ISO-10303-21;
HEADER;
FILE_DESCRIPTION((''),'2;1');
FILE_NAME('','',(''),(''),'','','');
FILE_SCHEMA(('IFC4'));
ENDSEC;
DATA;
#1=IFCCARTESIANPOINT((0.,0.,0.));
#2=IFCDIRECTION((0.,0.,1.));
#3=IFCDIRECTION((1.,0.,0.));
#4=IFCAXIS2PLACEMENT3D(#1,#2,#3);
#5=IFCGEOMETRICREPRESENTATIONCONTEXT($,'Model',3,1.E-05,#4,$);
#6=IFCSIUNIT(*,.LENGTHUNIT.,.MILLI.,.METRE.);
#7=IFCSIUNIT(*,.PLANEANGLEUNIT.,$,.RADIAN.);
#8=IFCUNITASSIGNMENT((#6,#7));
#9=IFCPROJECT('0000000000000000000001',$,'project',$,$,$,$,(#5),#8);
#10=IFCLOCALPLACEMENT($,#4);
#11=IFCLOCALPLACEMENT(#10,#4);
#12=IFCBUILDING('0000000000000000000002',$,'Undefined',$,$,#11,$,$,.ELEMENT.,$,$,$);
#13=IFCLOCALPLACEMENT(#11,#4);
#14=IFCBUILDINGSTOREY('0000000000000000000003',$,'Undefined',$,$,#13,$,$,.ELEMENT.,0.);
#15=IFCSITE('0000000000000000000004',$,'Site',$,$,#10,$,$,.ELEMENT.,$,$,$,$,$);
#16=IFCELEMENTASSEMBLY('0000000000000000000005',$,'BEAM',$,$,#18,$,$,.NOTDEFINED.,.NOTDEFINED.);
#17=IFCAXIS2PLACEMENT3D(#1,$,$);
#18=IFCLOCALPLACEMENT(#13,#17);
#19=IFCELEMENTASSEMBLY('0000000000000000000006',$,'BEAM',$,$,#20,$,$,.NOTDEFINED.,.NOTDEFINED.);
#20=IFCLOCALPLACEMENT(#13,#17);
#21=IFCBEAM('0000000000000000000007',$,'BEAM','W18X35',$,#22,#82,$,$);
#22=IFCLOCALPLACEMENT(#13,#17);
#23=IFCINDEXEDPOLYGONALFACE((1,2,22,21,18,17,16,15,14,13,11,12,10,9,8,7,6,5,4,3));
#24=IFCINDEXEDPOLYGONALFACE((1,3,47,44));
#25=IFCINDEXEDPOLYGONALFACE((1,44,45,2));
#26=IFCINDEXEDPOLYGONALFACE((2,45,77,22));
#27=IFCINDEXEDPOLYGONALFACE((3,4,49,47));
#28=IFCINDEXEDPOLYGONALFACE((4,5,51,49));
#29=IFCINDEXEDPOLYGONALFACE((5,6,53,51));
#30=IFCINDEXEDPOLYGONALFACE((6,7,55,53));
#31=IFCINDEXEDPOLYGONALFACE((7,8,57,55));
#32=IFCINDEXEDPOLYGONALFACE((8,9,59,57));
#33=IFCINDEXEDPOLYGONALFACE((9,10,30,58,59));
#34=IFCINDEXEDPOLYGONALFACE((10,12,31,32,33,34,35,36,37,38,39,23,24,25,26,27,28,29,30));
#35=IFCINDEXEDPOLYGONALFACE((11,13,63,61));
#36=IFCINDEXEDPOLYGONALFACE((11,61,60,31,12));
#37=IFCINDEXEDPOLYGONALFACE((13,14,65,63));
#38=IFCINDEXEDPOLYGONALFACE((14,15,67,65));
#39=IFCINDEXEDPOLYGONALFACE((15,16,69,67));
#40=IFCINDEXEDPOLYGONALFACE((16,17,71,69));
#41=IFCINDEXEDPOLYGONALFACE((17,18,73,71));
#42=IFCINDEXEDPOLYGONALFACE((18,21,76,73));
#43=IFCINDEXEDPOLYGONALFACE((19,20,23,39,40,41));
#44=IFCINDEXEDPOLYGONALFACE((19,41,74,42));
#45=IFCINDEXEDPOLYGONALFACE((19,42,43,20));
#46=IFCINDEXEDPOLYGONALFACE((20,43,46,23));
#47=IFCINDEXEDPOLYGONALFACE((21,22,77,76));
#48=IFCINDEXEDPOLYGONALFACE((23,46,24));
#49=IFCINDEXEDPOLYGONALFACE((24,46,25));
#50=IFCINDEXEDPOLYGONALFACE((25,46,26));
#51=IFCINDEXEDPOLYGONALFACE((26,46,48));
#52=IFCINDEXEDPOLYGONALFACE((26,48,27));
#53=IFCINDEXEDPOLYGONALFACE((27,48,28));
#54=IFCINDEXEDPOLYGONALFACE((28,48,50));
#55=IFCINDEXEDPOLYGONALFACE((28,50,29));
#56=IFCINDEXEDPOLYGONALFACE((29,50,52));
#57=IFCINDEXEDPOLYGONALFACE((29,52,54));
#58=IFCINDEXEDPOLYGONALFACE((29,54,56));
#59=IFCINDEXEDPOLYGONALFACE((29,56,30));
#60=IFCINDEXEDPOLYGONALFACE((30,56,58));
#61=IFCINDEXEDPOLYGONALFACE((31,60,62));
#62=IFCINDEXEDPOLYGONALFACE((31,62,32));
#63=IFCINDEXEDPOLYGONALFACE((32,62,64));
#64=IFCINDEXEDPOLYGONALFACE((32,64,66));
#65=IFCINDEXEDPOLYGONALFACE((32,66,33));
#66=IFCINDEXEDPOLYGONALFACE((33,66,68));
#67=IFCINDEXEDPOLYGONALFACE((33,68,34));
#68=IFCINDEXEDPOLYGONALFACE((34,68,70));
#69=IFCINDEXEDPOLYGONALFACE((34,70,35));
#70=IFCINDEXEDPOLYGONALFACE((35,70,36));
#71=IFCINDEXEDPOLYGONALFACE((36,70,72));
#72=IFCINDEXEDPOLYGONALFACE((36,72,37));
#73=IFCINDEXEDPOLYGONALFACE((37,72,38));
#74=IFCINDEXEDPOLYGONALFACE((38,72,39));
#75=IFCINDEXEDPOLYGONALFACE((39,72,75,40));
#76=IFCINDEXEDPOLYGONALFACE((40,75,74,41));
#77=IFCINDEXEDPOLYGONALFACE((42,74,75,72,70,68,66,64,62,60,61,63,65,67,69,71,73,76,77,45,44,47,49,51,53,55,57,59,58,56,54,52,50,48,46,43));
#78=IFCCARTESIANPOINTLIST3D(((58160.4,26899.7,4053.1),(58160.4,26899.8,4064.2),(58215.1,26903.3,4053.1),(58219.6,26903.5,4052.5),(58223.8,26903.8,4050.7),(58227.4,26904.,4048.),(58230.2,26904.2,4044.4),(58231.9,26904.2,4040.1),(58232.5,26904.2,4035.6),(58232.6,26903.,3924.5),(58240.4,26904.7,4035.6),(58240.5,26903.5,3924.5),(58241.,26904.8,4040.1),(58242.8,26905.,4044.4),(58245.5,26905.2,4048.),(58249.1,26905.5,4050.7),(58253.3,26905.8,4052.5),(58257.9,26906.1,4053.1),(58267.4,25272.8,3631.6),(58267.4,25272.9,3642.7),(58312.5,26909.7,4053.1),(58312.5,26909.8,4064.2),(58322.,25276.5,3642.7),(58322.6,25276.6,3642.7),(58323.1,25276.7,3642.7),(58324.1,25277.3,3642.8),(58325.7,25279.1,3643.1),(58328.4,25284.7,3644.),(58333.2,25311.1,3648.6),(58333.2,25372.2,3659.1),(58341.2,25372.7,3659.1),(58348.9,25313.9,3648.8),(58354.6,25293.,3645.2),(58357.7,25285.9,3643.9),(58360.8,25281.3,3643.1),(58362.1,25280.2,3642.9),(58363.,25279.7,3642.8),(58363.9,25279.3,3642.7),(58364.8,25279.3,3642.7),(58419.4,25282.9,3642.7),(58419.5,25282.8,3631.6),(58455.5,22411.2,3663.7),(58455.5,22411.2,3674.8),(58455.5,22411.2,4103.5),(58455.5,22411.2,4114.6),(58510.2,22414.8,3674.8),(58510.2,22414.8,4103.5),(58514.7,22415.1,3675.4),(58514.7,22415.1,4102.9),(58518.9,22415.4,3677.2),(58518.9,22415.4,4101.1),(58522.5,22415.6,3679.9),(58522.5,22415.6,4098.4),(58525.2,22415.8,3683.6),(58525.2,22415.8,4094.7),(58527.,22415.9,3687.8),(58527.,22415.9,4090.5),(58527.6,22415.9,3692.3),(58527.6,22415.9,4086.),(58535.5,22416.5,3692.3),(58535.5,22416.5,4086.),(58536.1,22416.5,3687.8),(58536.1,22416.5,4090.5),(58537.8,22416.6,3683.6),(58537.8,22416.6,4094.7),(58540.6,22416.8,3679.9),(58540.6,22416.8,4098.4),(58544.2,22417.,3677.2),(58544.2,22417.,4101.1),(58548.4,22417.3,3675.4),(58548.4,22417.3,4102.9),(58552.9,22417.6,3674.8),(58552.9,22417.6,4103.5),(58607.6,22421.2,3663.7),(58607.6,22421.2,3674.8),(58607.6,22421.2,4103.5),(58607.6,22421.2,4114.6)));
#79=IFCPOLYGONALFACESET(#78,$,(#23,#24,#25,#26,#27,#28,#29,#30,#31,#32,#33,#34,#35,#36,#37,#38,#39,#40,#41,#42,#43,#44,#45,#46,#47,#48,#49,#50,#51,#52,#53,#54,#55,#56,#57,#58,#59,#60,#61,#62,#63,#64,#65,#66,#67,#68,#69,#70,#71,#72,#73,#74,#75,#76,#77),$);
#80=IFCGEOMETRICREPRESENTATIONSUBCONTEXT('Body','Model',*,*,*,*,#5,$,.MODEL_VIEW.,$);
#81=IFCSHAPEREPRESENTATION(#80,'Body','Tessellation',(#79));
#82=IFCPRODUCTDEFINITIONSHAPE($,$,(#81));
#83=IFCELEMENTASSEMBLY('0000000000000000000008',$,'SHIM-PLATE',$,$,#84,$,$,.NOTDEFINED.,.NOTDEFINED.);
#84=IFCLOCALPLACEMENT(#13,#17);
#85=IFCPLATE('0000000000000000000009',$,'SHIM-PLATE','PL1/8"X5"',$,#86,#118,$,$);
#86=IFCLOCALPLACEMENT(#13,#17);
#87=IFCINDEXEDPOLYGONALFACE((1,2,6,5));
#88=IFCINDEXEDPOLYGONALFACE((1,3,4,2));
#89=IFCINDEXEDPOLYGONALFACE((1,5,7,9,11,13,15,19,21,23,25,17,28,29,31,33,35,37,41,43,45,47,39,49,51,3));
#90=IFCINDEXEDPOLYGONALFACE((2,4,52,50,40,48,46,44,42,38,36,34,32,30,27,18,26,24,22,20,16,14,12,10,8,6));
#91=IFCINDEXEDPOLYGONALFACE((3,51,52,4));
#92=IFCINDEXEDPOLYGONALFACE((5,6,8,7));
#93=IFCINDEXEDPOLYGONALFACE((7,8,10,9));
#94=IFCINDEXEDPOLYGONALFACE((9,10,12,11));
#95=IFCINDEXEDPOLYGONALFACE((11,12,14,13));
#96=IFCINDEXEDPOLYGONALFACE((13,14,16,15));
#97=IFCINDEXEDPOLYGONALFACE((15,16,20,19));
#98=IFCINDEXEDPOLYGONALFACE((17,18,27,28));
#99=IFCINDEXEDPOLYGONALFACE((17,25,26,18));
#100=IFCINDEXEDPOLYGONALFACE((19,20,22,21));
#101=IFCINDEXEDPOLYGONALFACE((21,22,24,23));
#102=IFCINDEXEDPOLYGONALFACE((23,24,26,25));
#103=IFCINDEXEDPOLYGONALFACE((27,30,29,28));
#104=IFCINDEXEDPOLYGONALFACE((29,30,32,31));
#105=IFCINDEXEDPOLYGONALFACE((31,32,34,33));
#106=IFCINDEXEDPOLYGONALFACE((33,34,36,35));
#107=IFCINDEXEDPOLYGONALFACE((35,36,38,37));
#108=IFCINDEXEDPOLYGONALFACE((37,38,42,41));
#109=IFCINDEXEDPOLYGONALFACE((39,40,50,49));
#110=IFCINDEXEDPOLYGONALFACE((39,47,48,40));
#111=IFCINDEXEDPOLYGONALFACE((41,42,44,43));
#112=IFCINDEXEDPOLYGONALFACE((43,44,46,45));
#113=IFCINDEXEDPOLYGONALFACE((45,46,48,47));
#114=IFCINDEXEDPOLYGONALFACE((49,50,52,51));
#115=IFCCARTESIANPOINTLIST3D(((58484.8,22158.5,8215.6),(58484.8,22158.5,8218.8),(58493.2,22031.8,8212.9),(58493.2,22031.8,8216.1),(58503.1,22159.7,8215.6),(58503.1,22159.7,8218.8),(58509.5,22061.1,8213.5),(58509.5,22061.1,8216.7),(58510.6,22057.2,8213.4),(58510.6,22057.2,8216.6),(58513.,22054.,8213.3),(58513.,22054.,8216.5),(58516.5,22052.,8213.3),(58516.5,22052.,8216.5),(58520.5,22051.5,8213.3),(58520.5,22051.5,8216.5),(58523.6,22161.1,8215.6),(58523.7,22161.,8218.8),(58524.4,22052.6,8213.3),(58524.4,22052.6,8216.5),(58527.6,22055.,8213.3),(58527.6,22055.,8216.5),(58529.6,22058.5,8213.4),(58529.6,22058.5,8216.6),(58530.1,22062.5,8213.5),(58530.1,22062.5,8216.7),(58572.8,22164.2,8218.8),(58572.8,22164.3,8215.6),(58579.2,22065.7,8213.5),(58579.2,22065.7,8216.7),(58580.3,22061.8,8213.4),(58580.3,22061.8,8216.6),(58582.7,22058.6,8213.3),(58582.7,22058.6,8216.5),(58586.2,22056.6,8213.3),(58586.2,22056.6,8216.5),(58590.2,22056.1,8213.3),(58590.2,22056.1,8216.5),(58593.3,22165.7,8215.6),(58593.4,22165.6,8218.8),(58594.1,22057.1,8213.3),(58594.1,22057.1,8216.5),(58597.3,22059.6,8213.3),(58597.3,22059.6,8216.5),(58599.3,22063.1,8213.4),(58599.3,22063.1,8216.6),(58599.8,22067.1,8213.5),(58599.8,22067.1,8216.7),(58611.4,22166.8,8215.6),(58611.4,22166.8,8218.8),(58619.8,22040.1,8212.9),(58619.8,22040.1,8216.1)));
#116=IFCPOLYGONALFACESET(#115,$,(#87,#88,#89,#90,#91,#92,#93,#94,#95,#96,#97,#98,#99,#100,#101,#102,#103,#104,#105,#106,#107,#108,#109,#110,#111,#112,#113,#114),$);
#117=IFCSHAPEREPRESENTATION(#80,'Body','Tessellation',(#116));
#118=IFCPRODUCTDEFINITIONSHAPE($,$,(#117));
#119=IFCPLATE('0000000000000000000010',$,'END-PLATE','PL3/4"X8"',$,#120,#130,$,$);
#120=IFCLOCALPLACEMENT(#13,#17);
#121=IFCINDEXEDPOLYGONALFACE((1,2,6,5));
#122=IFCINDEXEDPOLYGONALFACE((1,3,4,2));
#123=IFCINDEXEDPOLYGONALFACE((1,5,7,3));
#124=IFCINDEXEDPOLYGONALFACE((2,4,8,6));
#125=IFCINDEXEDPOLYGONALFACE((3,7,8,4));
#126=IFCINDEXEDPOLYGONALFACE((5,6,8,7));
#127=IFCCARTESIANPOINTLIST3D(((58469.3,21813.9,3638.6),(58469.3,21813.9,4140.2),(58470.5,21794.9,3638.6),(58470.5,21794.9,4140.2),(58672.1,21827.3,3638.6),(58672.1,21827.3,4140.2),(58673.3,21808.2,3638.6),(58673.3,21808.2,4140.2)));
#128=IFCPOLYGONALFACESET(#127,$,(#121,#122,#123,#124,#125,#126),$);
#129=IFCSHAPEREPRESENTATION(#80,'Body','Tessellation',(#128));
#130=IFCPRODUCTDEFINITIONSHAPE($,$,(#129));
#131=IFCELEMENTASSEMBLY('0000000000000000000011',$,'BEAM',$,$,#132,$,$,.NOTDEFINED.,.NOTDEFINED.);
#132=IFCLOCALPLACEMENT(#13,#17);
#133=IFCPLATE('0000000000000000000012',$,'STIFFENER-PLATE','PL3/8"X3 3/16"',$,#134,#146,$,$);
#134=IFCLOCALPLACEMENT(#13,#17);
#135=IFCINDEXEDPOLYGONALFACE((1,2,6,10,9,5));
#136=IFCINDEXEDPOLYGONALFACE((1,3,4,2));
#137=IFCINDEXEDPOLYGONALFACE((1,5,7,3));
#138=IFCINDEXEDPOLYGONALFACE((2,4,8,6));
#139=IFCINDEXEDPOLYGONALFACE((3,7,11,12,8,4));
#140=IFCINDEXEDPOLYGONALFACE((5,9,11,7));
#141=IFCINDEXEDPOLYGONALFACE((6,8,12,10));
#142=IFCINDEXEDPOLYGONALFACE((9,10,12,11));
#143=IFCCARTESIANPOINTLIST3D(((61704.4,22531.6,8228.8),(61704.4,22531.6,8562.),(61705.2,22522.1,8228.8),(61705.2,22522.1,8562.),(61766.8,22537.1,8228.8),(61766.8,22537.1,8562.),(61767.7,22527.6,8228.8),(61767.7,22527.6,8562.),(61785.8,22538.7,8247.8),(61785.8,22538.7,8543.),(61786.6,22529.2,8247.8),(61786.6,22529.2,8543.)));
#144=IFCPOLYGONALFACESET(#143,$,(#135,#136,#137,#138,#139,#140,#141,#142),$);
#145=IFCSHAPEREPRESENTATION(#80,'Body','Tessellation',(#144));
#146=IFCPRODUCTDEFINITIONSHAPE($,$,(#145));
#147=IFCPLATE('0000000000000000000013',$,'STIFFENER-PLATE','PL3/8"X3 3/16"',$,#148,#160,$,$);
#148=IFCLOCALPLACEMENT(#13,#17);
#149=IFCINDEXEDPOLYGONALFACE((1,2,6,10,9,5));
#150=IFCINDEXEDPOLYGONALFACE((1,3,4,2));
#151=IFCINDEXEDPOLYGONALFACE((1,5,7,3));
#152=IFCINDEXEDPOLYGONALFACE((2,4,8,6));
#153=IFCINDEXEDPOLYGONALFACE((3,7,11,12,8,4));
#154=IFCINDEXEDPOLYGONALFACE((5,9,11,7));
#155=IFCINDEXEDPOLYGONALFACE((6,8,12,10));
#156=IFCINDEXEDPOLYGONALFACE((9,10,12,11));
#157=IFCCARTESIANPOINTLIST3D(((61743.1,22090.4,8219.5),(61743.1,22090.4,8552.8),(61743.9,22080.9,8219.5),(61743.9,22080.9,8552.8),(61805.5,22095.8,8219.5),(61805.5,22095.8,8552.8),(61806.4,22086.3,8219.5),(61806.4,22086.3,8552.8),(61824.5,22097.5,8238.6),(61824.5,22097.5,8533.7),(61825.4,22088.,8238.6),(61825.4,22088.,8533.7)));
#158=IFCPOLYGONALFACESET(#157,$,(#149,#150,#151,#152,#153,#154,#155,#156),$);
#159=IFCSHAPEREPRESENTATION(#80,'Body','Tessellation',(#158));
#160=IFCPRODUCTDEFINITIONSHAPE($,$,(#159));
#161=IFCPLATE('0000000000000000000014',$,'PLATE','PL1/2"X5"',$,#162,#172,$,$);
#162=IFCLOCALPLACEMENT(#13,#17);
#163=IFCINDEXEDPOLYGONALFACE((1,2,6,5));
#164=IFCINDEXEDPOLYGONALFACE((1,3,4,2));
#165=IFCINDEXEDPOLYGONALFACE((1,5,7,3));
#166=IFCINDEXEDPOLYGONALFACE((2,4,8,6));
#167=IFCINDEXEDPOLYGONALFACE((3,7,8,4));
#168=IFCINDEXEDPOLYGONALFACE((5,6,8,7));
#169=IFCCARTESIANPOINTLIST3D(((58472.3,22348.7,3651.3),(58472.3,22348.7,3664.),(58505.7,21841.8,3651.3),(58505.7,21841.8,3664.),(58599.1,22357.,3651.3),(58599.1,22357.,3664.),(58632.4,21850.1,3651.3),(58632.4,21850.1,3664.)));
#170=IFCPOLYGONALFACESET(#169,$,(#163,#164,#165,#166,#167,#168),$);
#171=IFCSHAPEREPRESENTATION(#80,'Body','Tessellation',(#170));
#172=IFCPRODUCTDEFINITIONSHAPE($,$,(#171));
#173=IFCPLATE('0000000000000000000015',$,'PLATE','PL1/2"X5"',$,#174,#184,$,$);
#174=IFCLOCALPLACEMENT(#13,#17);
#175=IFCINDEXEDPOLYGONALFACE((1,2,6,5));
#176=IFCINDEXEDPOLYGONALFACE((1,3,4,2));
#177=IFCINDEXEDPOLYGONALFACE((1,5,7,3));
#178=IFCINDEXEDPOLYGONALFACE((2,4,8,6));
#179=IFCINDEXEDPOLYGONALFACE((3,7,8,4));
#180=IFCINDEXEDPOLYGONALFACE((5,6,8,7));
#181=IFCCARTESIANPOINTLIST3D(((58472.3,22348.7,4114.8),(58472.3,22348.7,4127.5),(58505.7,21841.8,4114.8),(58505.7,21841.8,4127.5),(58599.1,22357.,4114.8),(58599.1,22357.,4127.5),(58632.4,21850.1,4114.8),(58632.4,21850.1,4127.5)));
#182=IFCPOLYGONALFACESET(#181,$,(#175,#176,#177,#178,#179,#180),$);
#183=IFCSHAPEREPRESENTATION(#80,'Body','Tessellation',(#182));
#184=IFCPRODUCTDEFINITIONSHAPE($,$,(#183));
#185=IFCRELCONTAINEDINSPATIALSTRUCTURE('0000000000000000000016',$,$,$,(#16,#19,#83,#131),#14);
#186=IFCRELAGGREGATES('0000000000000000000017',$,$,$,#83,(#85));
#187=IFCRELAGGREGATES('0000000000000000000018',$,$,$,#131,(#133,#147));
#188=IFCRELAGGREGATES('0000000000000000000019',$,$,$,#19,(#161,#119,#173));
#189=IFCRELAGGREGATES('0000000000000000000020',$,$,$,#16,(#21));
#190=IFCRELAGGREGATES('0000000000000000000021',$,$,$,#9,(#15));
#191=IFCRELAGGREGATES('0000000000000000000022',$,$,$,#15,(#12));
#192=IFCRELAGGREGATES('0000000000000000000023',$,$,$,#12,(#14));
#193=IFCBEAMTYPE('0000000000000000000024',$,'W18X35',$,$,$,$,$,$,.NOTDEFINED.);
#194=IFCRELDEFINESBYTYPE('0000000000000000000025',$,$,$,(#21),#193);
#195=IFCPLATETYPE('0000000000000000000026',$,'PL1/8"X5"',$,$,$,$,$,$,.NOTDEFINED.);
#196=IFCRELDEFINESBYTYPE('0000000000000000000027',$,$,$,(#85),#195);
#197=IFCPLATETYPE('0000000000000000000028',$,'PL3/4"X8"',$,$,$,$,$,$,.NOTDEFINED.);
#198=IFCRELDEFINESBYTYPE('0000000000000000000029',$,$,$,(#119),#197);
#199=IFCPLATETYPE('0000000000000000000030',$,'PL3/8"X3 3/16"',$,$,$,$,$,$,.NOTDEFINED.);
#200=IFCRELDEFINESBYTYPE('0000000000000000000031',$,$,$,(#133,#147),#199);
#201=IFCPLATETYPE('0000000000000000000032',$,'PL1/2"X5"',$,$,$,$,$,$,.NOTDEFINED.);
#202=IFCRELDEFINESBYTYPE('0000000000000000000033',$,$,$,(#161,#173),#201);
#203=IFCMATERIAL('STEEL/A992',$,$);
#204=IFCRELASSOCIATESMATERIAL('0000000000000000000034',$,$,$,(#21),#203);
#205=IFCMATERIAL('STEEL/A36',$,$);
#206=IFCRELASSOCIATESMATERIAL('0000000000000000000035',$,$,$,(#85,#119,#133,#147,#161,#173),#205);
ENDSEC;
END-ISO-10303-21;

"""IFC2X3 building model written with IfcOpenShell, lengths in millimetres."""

from ifc_helpers import new_model, si_unit, frame, origin_with_axes, origin_2d_with_axis, place, context, subcontext, project, spatial, polyline, i_section, outline, extrude, boolean, halfspace, material, type_object, element, aggregate, save


model = new_model("IFC2X3")

# Units and contexts
model_context = context("Model", 3, precision=1e-05, world=origin_with_axes())
body_context = subcontext(model_context, "Body", "Model", "MODEL_VIEW")
ifc_project = project(units=[si_unit("LENGTHUNIT", "METRE", prefix="MILLI"), si_unit("PLANEANGLEUNIT", "RADIAN")], contexts=[model_context])

# Site, building, storey
site_placement = place(None, origin_with_axes())
site = spatial("IfcSite", under=ifc_project, at=site_placement, Name="Site", CompositionType="ELEMENT")
building_placement = place(site_placement, origin_with_axes())
building = spatial("IfcBuilding", under=site, at=building_placement, Name="Undefined", CompositionType="ELEMENT")
storey_placement = place(building_placement, origin_with_axes())
storey = spatial("IfcBuildingStorey", under=building, at=storey_placement, Name="Undefined", CompositionType="ELEMENT", Elevation=0.0)

# Element assembly
assembly_1_placement = place(storey_placement, origin_with_axes())
assembly_1 = element("IfcElementAssembly", 1, at=assembly_1_placement, inside=storey, Name="BEAM", AssemblyPlace="NOTDEFINED", PredefinedType="NOTDEFINED")

# Element assembly
ifc_material_1 = material(Name="STEEL/A36")
assembly_2_placement = place(storey_placement, origin_with_axes())
assembly_2 = element("IfcElementAssembly", 2, at=assembly_2_placement, inside=storey, Name="BEAM", AssemblyPlace="NOTDEFINED", PredefinedType="NOTDEFINED")
ifc_material_2 = material(Name="STEEL/A992")
beam_type_1 = type_object("IfcBeamType", Name="W18X35", PredefinedType="NOTDEFINED")

# Beam
beam_1_placement = place(assembly_1_placement, frame((58533.0, 22394.7, 3889.4), z_axis=(-0.000735, 0.011177, 0.999937), x_axis=(-0.065594, 0.997783, -0.011201)))
beam_1 = element("IfcBeam", 3, at=beam_1_placement, type_object=beam_type_1, material=ifc_material_2, Name="BEAM", Description="W18X35", context=body_context, shape_type="CSG", body=[
    boolean("DIFFERENCE", boolean("DIFFERENCE", extrude(i_section(OverallWidth=152.4, OverallDepth=450.9, WebThickness=7.9, FlangeThickness=11.1, FilletRadius=17.5, at=origin_2d_with_axis()), frame((4517.6, 0.0, 0.0), z_axis=(-1.0, 0.0, 0.0), x_axis=(0.0, -1.0, 0.0)), (0.0, 0.0, 1.0), 4523.6), extrude(outline(polyline([(0.0, 0.0), (25.4, 0.0), (25.4, 336.6), (-1625.6, 336.6), (-1625.6, 300.0), (0.0, 0.0)])), frame((4517.6, -152.4, 85.7), z_axis=(0.0, 1.0, 0.0), x_axis=(1.0, 0.0, 0.0)), (0.0, 0.0, 1.0), 304.8)), halfspace(frame((24.4, 101.6, -250.8), z_axis=(0.999937, -0.000028, 0.011201), x_axis=(-0.011201, 0.0, 0.999937)), True)),
])

# Element assembly, plate
assembly_3_placement = place(storey_placement, origin_with_axes())
assembly_3 = element("IfcElementAssembly", 4, at=assembly_3_placement, inside=storey, Name="SHIM-PLATE", AssemblyPlace="NOTDEFINED", PredefinedType="NOTDEFINED")
plate_type_1 = type_object("IfcPlateType", Name="PL1/8\"X5\"", PredefinedType="NOTDEFINED")
plate_1_placement = place(assembly_3_placement, frame((58489.0, 22095.1, 8215.8), z_axis=(-0.001284, 0.020943, -0.99978), x_axis=(0.997848, 0.065573, 0.000092)))
plate_1 = element("IfcPlate", 5, at=plate_1_placement, type_object=plate_type_1, material=ifc_material_1, Name="SHIM-PLATE", Description="PL1/8\"X5\"", context=body_context, shape_type="CSG", body=[
    boolean("DIFFERENCE", boolean("DIFFERENCE", extrude(outline(polyline([(0.0, -63.5), (0.0, 63.5), (126.9, 63.5), (126.9, -63.5), (0.0, -63.5)])), frame((0.0, 0.0, -1.6), z_axis=(0.0, 0.0, 1.0), x_axis=(1.0, 0.0, 0.0)), (0.0, 0.0, 1.0), 3.2), extrude(outline(polyline([(0.0, 10.3), (0.8, 6.4), (3.0, 3.0), (6.4, 0.8), (10.3, 0.0), (10.3, 0.0), (14.3, 0.8), (17.6, 3.0), (19.9, 6.4), (20.6, 10.3), (20.6, 109.1), (0.0, 109.1), (0.0, 10.3)])), frame((18.3, 45.7, 4.5), z_axis=(0.000092, -0.020982, -0.99978), x_axis=(1.0, 0.000004, 0.000092)), (0.0, 0.0, 1.0), 11.0)), extrude(outline(polyline([(0.0, 10.3), (0.8, 6.4), (3.0, 3.0), (6.4, 0.8), (10.3, 0.0), (10.3, 0.0), (14.3, 0.8), (17.6, 3.0), (19.9, 6.4), (20.6, 10.3), (20.6, 109.1), (0.0, 109.1), (0.0, 10.3)])), frame((88.1, 45.7, 4.5), z_axis=(0.000092, -0.020982, -0.99978), x_axis=(1.0, 0.000004, 0.000092)), (0.0, 0.0, 1.0), 11.0)),
])
aggregate(assembly_3, [plate_1])

# Plate
plate_type_2 = type_object("IfcPlateType", Name="PL3/4\"X8\"", PredefinedType="NOTDEFINED")
plate_2_placement = place(assembly_2_placement, frame((58571.3, 21811.1, 3638.6), z_axis=(-0.065571, 0.997848, 0.0), x_axis=(0.0, 0.0, 1.0)))
plate_2 = element("IfcPlate", 6, at=plate_2_placement, type_object=plate_type_2, material=ifc_material_1, Name="END-PLATE", Description="PL3/4\"X8\"", context=body_context, shape_type="SweptSolid", body=[
    extrude(outline(polyline([(0.0, -101.6), (0.0, 101.6), (501.7, 101.6), (501.7, -101.6), (0.0, -101.6)])), frame((0.0, 0.0, -9.5), z_axis=(0.0, 0.0, 1.0), x_axis=(1.0, 0.0, 0.0)), (0.0, 0.0, 1.0), 19.1),
])

# Element assembly, plates
assembly_4_placement = place(storey_placement, origin_with_axes())
assembly_4 = element("IfcElementAssembly", 7, at=assembly_4_placement, inside=storey, Name="BEAM", AssemblyPlace="NOTDEFINED", PredefinedType="NOTDEFINED")
plate_type_3 = type_object("IfcPlateType", Name="PL3/8\"X3 3/16\"", PredefinedType="NOTDEFINED")
plate_3_placement = place(assembly_4_placement, frame((61704.8, 22526.8, 8228.8), z_axis=(0.087396, -0.996174, 0.0), x_axis=(0.996174, 0.087396, 0.0)))
plate_3 = element("IfcPlate", 8, at=plate_3_placement, type_object=plate_type_3, material=ifc_material_1, Name="STIFFENER-PLATE", Description="PL3/8\"X3 3/16\"", context=body_context, shape_type="SweptSolid", body=[
    extrude(outline(polyline([(0.0, 0.0), (62.7, 0.0), (81.8, 19.0), (81.8, 314.2), (62.7, 333.2), (0.0, 333.2), (0.0, 0.0)])), frame((0.0, 0.0, -4.8), z_axis=(0.0, 0.0, 1.0), x_axis=(1.0, 0.0, 0.0)), (0.0, 0.0, 1.0), 9.5),
])
plate_4_placement = place(assembly_4_placement, frame((61743.5, 22085.6, 8219.5), z_axis=(0.087396, -0.996174, 0.0), x_axis=(0.996174, 0.087396, 0.0)))
plate_4 = element("IfcPlate", 9, at=plate_4_placement, type_object=plate_type_3, material=ifc_material_1, Name="STIFFENER-PLATE", Description="PL3/8\"X3 3/16\"", context=body_context, shape_type="SweptSolid", body=[
    extrude(outline(polyline([(0.0, 0.0), (62.7, 0.0), (81.8, 19.0), (81.8, 314.2), (62.7, 333.2), (0.0, 333.2), (0.0, 0.0)])), frame((0.0, 0.0, -4.8), z_axis=(0.0, 0.0, 1.0), x_axis=(1.0, 0.0, 0.0)), (0.0, 0.0, 1.0), 9.5),
])
aggregate(assembly_4, [plate_3, plate_4])

# Plates
plate_type_4 = type_object("IfcPlateType", Name="PL1/2\"X5\"", PredefinedType="NOTDEFINED")
plate_5_placement = place(assembly_2_placement, frame((58569.0, 21845.9, 3657.6), z_axis=(0.0, 0.0, 1.0), x_axis=(-0.065571, 0.997848, 0.0)))
plate_5 = element("IfcPlate", 10, at=plate_5_placement, type_object=plate_type_4, material=ifc_material_1, Name="PLATE", Description="PL1/2\"X5\"", context=body_context, shape_type="SweptSolid", body=[
    extrude(outline(polyline([(0.0, -63.5), (0.0, 63.5), (508.0, 63.5), (508.0, -63.5), (0.0, -63.5)])), frame((0.0, 0.0, -6.3), z_axis=(0.0, 0.0, 1.0), x_axis=(1.0, 0.0, 0.0)), (0.0, 0.0, 1.0), 12.7),
])
plate_6_placement = place(assembly_2_placement, frame((58569.0, 21845.9, 4121.1), z_axis=(0.0, 0.0, 1.0), x_axis=(-0.065571, 0.997848, 0.0)))
plate_6 = element("IfcPlate", 11, at=plate_6_placement, type_object=plate_type_4, material=ifc_material_1, Name="PLATE", Description="PL1/2\"X5\"", context=body_context, shape_type="SweptSolid", body=[
    extrude(outline(polyline([(0.0, -63.5), (0.0, 63.5), (508.0, 63.5), (508.0, -63.5), (0.0, -63.5)])), frame((0.0, 0.0, -6.3), z_axis=(0.0, 0.0, 1.0), x_axis=(1.0, 0.0, 0.0)), (0.0, 0.0, 1.0), 12.7),
])
aggregate(assembly_2, [plate_5, plate_2, plate_6])

aggregate(assembly_1, [beam_1])

save(model, "model.ifc")
